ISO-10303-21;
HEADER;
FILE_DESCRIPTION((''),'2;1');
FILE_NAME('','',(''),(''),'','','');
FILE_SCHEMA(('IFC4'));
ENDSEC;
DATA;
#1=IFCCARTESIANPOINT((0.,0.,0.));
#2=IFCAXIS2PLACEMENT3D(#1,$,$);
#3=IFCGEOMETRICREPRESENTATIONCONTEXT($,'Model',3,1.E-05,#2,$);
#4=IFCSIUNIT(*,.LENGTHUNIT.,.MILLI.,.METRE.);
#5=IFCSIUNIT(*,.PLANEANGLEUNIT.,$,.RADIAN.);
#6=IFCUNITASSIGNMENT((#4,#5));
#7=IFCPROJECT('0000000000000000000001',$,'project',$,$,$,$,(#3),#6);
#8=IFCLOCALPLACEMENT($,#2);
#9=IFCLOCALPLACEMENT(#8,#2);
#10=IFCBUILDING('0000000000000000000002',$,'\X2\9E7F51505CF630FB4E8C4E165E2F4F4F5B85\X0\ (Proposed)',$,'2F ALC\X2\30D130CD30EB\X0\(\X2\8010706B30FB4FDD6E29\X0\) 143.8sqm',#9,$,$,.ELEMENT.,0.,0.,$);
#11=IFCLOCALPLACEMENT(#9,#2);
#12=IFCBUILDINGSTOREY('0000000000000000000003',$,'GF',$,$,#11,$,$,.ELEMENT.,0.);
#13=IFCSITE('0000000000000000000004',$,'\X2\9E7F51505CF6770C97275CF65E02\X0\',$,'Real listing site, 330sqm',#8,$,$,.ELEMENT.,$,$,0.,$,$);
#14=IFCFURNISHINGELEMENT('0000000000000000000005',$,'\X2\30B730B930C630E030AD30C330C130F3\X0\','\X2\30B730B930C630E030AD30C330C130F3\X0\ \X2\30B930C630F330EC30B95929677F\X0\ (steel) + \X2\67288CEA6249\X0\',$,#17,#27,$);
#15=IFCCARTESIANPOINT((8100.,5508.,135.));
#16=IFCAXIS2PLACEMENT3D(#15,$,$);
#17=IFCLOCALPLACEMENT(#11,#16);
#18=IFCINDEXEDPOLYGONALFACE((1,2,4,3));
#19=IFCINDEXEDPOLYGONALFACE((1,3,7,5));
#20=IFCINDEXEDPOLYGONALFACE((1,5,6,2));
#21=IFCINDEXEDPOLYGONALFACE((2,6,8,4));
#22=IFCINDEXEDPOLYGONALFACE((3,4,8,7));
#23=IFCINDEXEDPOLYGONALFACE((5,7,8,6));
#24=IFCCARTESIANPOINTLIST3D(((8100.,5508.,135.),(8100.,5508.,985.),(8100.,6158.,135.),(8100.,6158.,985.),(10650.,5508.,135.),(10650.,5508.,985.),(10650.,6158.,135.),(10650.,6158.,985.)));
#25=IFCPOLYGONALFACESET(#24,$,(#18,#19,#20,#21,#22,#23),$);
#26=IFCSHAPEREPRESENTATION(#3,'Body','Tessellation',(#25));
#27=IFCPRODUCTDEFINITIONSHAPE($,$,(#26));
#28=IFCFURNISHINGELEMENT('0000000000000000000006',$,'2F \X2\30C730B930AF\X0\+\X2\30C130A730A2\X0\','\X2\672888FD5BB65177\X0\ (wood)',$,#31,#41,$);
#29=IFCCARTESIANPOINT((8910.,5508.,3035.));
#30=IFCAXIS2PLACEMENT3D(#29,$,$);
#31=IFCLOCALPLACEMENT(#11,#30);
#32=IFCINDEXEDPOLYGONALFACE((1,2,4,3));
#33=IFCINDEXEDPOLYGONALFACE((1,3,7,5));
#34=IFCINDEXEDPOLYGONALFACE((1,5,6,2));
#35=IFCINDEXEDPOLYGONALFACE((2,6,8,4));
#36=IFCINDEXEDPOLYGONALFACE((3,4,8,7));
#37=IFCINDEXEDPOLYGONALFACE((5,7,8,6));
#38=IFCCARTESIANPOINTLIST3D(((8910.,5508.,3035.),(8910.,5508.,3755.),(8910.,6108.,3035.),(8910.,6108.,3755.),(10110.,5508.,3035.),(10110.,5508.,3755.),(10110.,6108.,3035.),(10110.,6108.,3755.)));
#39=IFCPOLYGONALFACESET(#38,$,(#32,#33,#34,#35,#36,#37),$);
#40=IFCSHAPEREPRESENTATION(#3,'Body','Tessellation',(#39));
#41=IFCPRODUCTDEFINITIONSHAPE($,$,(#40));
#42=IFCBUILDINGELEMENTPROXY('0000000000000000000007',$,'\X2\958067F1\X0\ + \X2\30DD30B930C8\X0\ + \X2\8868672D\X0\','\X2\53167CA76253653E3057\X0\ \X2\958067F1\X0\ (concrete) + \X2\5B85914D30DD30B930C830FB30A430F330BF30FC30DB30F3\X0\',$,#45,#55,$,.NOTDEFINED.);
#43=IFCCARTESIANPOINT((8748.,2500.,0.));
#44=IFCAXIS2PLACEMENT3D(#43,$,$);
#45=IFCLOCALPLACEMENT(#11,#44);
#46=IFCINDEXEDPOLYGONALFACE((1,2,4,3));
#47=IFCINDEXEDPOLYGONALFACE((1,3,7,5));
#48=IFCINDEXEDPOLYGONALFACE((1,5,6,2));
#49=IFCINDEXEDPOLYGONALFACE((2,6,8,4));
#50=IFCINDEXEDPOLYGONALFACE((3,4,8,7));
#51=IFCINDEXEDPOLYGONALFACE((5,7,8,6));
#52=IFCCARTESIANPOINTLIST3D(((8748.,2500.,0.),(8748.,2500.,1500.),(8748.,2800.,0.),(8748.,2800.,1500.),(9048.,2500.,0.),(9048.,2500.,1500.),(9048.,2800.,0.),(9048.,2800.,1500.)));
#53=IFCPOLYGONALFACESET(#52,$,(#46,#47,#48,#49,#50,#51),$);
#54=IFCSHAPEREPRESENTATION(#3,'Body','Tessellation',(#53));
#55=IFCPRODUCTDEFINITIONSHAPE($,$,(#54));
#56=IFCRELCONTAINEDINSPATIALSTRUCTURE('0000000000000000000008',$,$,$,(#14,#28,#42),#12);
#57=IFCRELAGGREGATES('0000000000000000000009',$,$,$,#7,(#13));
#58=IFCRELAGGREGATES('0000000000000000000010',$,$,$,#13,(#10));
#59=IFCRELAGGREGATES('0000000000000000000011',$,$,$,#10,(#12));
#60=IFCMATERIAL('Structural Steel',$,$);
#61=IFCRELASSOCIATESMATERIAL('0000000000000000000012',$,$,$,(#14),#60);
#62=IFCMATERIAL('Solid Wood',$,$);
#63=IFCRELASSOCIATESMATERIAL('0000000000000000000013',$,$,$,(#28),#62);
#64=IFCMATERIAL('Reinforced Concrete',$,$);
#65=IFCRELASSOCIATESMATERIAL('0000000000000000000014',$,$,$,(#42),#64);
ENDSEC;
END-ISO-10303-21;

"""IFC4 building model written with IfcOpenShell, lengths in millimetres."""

from ifc_helpers import new_model, si_unit, frame, frame_2d, origin, place, context, project, spatial, rectangle, extrude, material, element, save


model = new_model("IFC4")

# Units and contexts
model_context = context("Model", 3, precision=1e-05, world=origin())
ifc_project = project(units=[si_unit("LENGTHUNIT", "METRE", prefix="MILLI"), si_unit("PLANEANGLEUNIT", "RADIAN")], contexts=[model_context])

# Site, building, storey
site_placement = place(None, origin())
site = spatial("IfcSite", under=ifc_project, at=site_placement, Name="鹿児島県霧島市", ObjectType="Real listing site, 330sqm", CompositionType="ELEMENT", RefElevation=0.0)
building_placement = place(site_placement, origin())
building = spatial("IfcBuilding", under=site, at=building_placement, Name="鹿児島・二世帯住宅 (Proposed)", ObjectType="2F ALCパネル(耐火・保温) 143.8sqm", CompositionType="ELEMENT", ElevationOfRefHeight=0.0, ElevationOfTerrain=0.0)
storey_placement = place(building_placement, origin())
storey = spatial("IfcBuildingStorey", under=building, at=storey_placement, Name="GF", CompositionType="ELEMENT", Elevation=0.0)

# Shared definitions
ifc_material_1 = material(Name="Solid Wood")

# Shared definitions
ifc_material_2 = material(Name="Reinforced Concrete")

# Shared definitions
ifc_material_3 = material(Name="Structural Steel")

# Furnishing elements
furnishing_1_placement = place(storey_placement, frame((8100.0, 5508.0, 135.0)))
element("IfcFurnishingElement", 1, at=furnishing_1_placement, inside=storey, material=ifc_material_3, Name="システムキッチン", Description="システムキッチン ステンレス天板 (steel) + 木質扉", context=model_context, shape_type="SweptSolid", body=[
    extrude(rectangle(XDim=2550.0, YDim=650.0, at=frame_2d((1275.0, 325.0))), frame((8100.0, 5508.0, 135.0)), (0.0, 0.0, 1.0), 850.0),
])
furnishing_2_placement = place(storey_placement, frame((8910.0, 5508.0, 3035.0)))
element("IfcFurnishingElement", 2, at=furnishing_2_placement, inside=storey, material=ifc_material_1, Name="2F デスク+チェア", Description="木製家具 (wood)", context=model_context, shape_type="SweptSolid", body=[
    extrude(rectangle(XDim=1200.0, YDim=600.0, at=frame_2d((600.0, 300.0))), frame((8910.0, 5508.0, 3035.0)), (0.0, 0.0, 1.0), 720.0),
])

# Building element proxy
proxy_placement = place(storey_placement, frame((8748.0, 2500.0, 0.0)))
element("IfcBuildingElementProxy", 3, at=proxy_placement, inside=storey, material=ifc_material_2, Name="門柱 + ポスト + 表札", Description="化粧打放し 門柱 (concrete) + 宅配ポスト・インターホン", PredefinedType="NOTDEFINED", context=model_context, shape_type="SweptSolid", body=[
    extrude(rectangle(XDim=300.0, YDim=300.0, at=frame_2d((150.0, 150.0))), frame((8748.0, 2500.0, 0.0)), (0.0, 0.0, 1.0), 1500.0),
])

save(model, "model.ifc")
